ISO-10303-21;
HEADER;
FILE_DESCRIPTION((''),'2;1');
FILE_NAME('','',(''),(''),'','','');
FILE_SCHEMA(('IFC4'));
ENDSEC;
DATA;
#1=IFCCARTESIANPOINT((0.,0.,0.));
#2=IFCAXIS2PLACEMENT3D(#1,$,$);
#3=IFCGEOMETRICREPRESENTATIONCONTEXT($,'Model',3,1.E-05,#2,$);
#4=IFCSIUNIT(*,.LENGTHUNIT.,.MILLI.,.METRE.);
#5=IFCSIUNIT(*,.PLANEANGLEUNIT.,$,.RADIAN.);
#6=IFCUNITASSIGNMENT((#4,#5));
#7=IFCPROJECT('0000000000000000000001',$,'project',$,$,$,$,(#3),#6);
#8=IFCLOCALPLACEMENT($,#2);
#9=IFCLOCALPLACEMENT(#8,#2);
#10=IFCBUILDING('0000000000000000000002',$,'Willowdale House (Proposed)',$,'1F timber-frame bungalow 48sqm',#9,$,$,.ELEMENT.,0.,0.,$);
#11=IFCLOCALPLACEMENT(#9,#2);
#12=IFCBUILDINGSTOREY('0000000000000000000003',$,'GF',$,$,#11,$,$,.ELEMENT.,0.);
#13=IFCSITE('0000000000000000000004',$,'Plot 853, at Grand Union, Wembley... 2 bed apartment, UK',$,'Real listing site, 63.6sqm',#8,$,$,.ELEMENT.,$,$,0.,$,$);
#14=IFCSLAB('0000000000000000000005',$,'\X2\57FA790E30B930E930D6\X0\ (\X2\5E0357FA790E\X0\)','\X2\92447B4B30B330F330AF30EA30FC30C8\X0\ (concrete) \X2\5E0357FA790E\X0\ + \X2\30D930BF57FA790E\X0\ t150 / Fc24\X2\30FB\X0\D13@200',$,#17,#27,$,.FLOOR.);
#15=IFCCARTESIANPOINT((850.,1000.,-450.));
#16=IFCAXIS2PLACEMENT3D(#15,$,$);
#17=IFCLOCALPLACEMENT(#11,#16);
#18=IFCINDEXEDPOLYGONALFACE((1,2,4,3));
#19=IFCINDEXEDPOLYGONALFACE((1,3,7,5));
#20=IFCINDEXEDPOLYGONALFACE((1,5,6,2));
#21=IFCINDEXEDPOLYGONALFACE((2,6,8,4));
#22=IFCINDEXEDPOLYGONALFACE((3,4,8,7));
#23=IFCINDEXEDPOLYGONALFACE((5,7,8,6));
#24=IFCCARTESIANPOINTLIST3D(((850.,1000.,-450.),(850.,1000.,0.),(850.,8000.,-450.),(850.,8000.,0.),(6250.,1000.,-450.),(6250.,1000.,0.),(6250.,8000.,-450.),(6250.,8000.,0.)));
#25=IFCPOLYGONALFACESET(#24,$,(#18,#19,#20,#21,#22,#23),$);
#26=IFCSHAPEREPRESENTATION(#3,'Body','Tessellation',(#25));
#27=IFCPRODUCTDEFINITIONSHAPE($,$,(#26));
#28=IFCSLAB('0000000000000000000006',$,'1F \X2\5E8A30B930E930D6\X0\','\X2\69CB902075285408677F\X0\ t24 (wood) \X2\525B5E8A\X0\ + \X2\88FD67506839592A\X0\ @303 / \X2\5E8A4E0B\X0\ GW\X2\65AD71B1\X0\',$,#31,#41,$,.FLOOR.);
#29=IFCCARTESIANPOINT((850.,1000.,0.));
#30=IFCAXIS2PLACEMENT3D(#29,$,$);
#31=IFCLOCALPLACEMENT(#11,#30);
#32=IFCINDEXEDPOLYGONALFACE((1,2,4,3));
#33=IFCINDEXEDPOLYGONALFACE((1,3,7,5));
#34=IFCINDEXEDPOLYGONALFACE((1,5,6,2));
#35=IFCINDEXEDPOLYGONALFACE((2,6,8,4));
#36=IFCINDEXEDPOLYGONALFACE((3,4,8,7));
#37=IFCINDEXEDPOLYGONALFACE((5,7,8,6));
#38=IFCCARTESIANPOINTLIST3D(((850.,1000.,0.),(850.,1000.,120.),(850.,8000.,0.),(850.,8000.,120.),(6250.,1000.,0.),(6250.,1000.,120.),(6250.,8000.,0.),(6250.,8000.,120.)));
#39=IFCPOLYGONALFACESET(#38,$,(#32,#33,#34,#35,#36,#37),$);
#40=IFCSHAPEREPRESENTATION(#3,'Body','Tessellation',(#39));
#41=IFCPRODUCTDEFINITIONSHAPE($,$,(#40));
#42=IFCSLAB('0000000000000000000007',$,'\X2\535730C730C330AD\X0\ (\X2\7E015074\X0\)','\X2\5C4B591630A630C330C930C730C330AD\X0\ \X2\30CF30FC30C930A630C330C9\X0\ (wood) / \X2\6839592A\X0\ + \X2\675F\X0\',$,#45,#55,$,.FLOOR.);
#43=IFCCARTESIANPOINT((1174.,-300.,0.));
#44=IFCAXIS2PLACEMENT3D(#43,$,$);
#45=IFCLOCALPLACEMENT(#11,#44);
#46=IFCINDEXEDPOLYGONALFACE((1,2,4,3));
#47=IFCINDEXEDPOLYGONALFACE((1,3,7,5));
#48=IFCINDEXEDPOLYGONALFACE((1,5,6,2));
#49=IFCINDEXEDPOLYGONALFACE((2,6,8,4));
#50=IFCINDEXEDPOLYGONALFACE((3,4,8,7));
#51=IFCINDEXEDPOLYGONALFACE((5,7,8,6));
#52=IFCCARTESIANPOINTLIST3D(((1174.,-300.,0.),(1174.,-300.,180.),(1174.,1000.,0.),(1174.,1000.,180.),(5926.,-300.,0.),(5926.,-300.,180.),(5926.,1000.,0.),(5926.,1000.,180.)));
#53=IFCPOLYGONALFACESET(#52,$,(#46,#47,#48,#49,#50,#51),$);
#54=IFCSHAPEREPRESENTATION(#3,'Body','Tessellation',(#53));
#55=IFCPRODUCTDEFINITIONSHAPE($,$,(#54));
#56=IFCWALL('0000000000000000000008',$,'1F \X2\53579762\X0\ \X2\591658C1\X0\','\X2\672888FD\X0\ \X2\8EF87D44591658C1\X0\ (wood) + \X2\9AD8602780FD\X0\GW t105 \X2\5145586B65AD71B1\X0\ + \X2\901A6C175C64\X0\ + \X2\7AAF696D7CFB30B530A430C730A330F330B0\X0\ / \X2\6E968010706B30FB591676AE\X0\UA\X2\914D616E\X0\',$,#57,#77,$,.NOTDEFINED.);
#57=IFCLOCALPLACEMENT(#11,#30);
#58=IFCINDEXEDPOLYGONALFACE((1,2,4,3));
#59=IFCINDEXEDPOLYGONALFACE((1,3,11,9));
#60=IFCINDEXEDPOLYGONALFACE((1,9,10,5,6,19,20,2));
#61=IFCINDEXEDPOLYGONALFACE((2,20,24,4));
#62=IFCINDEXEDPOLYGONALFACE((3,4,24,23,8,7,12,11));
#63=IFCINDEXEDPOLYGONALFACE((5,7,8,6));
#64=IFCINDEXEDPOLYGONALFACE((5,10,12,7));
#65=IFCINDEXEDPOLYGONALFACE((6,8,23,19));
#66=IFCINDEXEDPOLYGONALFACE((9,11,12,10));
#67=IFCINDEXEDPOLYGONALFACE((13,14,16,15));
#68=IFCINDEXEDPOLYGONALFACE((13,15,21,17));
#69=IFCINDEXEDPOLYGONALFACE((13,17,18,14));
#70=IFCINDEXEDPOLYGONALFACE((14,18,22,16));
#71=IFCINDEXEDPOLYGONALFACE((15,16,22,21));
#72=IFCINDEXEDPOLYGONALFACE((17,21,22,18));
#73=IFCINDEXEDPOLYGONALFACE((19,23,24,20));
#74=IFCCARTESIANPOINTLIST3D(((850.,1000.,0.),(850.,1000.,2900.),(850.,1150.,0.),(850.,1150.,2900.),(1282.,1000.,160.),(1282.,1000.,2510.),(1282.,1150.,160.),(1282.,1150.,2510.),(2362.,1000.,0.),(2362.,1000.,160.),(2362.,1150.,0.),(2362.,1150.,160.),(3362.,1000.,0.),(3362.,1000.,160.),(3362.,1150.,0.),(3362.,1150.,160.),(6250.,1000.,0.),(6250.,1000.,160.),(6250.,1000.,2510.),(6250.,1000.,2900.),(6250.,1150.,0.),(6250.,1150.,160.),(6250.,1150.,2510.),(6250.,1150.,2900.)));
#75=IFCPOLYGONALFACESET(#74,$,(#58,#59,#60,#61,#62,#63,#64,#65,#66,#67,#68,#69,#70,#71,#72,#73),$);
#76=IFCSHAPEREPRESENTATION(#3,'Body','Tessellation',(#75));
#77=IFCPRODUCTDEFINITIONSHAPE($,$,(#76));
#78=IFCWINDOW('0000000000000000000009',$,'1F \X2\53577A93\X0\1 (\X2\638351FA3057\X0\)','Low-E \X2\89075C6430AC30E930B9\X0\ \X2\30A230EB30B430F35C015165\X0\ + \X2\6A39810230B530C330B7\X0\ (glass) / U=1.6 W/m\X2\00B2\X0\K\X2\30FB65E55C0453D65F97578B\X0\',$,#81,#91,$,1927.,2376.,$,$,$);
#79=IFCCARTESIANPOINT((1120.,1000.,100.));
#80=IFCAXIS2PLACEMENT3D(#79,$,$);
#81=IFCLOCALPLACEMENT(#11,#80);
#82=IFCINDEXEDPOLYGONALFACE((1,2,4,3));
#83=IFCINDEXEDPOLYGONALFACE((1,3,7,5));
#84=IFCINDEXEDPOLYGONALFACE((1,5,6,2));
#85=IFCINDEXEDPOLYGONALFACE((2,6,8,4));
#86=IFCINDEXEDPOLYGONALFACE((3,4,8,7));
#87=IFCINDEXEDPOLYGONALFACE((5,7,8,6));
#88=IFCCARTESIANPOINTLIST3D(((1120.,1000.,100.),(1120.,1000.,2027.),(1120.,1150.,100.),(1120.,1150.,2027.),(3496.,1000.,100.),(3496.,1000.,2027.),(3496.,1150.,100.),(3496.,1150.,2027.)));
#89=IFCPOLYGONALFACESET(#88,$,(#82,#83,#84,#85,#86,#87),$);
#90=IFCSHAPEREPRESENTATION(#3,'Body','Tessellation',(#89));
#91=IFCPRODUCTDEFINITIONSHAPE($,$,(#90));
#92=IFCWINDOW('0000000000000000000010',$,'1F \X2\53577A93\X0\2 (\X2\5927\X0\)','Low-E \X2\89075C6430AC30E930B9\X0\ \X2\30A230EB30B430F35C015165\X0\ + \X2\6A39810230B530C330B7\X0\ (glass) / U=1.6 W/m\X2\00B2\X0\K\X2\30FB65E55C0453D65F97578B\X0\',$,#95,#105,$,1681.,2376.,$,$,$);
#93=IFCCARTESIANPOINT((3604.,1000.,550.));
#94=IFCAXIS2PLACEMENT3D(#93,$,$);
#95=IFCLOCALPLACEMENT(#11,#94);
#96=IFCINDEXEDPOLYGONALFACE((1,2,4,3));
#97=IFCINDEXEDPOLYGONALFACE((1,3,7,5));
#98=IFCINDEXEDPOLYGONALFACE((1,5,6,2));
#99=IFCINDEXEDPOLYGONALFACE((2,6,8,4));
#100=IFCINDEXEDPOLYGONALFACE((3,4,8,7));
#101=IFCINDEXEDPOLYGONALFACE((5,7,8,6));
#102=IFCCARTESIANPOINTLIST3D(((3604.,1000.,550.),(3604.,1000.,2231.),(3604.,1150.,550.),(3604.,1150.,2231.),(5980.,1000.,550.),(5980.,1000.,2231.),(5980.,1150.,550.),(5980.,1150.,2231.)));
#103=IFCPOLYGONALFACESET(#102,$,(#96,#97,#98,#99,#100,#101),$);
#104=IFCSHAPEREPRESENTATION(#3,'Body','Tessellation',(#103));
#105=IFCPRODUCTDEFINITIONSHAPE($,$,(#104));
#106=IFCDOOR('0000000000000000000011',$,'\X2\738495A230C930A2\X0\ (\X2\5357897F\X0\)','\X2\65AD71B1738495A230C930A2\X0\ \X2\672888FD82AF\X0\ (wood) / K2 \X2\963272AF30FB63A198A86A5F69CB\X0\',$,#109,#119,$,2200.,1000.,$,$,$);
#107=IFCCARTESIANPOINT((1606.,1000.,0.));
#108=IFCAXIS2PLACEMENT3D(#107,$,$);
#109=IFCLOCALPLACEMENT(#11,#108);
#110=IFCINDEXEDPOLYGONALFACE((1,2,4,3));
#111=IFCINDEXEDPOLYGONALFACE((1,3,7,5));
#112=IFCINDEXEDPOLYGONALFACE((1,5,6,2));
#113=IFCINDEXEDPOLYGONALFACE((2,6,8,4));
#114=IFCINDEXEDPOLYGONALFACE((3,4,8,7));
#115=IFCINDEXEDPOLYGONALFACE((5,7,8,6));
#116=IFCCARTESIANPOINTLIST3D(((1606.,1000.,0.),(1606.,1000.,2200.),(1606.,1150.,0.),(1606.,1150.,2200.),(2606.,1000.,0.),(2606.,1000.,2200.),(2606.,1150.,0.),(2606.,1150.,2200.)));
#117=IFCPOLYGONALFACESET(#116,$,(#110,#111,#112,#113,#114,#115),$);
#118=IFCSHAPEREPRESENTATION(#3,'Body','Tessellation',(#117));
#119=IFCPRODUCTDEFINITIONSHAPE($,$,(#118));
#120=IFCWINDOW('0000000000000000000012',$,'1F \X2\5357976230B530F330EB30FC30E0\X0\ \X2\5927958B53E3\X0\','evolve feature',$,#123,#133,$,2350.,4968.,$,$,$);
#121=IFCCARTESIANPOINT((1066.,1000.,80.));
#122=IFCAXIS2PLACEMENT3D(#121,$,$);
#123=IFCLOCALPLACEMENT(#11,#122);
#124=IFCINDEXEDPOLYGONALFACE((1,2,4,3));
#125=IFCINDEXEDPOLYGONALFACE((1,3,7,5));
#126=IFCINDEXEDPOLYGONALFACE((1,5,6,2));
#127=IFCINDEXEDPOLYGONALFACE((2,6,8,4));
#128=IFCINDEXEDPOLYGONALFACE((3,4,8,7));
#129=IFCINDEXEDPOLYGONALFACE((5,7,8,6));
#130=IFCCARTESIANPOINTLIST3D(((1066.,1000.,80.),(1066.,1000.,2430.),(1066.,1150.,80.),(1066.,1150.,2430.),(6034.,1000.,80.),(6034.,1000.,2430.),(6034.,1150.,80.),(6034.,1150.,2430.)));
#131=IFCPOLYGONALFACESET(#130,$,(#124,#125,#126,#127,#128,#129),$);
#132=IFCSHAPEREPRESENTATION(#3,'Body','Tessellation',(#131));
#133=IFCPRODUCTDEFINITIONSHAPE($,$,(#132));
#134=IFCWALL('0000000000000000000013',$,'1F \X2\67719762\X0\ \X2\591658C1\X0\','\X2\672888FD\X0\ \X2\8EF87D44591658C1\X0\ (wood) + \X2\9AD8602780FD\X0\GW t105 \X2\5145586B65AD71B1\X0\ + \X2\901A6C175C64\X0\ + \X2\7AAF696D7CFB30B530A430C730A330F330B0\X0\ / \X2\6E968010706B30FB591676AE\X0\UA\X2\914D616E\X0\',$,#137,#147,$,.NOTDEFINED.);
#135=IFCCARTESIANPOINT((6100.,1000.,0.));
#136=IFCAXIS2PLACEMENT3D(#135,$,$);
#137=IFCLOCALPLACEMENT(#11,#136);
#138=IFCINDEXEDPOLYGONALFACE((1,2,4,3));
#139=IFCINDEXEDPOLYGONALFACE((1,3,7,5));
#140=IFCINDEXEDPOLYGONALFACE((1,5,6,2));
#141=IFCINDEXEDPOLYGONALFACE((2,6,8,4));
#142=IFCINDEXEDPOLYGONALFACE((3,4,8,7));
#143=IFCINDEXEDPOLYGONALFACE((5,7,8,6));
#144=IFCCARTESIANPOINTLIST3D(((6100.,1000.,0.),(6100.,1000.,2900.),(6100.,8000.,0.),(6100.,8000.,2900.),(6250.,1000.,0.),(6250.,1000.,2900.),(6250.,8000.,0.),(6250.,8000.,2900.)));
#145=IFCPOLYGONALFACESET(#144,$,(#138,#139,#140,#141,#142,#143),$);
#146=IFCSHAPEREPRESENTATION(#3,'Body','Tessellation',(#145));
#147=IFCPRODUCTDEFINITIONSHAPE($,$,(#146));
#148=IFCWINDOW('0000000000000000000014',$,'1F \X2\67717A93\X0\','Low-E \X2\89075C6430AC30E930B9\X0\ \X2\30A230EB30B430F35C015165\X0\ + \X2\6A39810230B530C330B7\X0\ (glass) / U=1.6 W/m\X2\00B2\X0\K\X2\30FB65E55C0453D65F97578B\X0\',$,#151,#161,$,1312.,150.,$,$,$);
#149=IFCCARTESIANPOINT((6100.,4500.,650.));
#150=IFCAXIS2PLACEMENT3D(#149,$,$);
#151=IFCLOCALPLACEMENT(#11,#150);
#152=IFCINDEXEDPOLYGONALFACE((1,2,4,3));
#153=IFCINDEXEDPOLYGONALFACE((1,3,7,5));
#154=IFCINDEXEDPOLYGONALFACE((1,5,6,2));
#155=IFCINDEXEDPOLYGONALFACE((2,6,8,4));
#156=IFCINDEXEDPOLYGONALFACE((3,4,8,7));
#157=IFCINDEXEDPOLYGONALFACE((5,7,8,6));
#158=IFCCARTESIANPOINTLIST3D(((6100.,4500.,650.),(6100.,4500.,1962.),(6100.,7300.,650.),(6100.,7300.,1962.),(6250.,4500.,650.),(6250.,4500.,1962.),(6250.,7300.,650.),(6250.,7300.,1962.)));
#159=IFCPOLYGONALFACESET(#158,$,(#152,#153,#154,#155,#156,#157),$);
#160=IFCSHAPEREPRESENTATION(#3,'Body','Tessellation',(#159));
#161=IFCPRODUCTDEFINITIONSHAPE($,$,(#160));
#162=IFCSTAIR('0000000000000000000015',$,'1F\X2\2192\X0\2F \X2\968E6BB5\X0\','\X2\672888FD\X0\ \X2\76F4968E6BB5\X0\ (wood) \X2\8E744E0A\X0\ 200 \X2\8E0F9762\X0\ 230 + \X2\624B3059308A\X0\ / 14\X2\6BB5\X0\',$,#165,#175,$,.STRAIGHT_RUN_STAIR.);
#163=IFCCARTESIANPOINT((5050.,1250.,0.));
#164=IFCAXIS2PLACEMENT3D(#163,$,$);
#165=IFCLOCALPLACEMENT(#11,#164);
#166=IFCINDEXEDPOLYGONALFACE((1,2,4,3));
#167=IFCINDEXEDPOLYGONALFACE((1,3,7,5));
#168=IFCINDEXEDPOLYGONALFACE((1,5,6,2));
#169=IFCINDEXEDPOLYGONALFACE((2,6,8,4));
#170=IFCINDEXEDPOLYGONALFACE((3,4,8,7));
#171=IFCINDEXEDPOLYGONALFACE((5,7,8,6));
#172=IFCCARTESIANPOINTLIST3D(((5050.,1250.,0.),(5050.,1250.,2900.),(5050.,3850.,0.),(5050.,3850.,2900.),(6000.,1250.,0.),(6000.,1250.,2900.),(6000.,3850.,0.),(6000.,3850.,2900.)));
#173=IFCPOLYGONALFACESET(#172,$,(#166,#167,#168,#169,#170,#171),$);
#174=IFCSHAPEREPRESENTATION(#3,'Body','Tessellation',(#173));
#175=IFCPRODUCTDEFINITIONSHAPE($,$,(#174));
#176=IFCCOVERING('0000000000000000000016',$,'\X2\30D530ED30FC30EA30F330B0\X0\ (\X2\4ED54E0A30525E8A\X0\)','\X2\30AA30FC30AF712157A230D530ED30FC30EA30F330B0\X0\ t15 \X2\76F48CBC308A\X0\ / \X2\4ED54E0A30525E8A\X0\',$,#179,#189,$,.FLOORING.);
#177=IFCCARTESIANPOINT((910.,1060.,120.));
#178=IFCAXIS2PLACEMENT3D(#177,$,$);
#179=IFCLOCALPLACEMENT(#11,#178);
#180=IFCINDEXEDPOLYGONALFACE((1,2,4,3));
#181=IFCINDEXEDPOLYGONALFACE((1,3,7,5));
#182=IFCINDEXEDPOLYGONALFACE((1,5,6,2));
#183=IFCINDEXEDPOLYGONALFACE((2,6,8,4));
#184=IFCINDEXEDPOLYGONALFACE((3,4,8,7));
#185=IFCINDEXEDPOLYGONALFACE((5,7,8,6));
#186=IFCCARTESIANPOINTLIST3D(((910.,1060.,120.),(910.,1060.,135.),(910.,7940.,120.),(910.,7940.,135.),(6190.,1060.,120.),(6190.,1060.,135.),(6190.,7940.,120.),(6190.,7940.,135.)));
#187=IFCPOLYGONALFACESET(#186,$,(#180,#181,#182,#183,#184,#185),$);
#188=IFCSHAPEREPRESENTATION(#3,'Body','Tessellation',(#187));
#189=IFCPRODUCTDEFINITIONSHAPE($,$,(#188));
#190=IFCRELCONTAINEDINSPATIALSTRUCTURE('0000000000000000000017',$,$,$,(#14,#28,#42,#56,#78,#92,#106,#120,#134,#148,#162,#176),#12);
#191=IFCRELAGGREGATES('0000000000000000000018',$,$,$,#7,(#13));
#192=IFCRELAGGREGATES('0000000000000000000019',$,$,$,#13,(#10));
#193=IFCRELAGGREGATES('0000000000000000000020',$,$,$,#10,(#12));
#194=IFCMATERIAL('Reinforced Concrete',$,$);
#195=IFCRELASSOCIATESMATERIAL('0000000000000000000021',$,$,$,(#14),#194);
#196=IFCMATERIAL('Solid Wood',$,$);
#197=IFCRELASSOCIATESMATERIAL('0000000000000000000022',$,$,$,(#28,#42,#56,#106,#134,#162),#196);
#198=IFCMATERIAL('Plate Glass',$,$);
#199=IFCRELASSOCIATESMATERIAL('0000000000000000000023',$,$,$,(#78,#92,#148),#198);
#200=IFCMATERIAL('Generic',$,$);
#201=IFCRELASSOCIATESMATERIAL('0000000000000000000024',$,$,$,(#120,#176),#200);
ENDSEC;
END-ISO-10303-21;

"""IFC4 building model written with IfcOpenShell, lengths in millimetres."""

from ifc_helpers import new_model, si_unit, frame, frame_2d, origin, place, context, project, spatial, rectangle, extrude, material, element, fill, save


model = new_model("IFC4")

# Units and contexts
model_context = context("Model", 3, precision=1e-05, world=origin())
ifc_project = project(units=[si_unit("LENGTHUNIT", "METRE", prefix="MILLI"), si_unit("PLANEANGLEUNIT", "RADIAN")], contexts=[model_context])

# Site, building, storey
site_placement = place(None, origin())
site = spatial("IfcSite", under=ifc_project, at=site_placement, Name="Plot 853, at Grand Union, Wembley... 2 bed apartment, UK", ObjectType="Real listing site, 63.6sqm", CompositionType="ELEMENT", RefElevation=0.0)
building_placement = place(site_placement, origin())
building = spatial("IfcBuilding", under=site, at=building_placement, Name="Willowdale House (Proposed)", ObjectType="1F timber-frame bungalow 48sqm", CompositionType="ELEMENT", ElevationOfRefHeight=0.0, ElevationOfTerrain=0.0)
storey_placement = place(building_placement, origin())
storey = spatial("IfcBuildingStorey", under=building, at=storey_placement, Name="GF", CompositionType="ELEMENT", Elevation=0.0)

# Slabs
ifc_material_1 = material(Name="Reinforced Concrete")
slab_1_placement = place(storey_placement, frame((850.0, 1000.0, -450.0)))
element("IfcSlab", 1, at=slab_1_placement, inside=storey, material=ifc_material_1, Name="基礎スラブ (布基礎)", Description="鉄筋コンクリート (concrete) 布基礎 + ベタ基礎 t150 / Fc24・D13@200", PredefinedType="FLOOR", context=model_context, shape_type="SweptSolid", body=[
    extrude(rectangle(XDim=5400.0, YDim=7000.0, at=frame_2d((2700.0, 3500.0))), frame((850.0, 1000.0, -450.0)), (0.0, 0.0, 1.0), 450.0),
])
ifc_material_2 = material(Name="Solid Wood")
slab_2_placement = place(storey_placement, frame((850.0, 1000.0, 0.0)))
element("IfcSlab", 2, at=slab_2_placement, inside=storey, material=ifc_material_2, Name="1F 床スラブ", Description="構造用合板 t24 (wood) 剛床 + 製材根太 @303 / 床下 GW断熱", PredefinedType="FLOOR", context=model_context, shape_type="SweptSolid", body=[
    extrude(rectangle(XDim=5400.0, YDim=7000.0, at=frame_2d((2700.0, 3500.0))), frame((850.0, 1000.0, 0.0)), (0.0, 0.0, 1.0), 120.0),
])
slab_3_placement = place(storey_placement, frame((1174.0, -300.0, 0.0)))
element("IfcSlab", 3, at=slab_3_placement, inside=storey, material=ifc_material_2, Name="南デッキ (縁側)", Description="屋外ウッドデッキ ハードウッド (wood) / 根太 + 束", PredefinedType="FLOOR", context=model_context, shape_type="SweptSolid", body=[
    extrude(rectangle(XDim=4752.0, YDim=1300.0, at=frame_2d((2376.0, 650.0))), frame((1174.0, -300.0, 0.0)), (0.0, 0.0, 1.0), 180.0),
])

# Wall, openings, windows, door
wall_1_placement = place(storey_placement, frame((850.0, 1000.0, 0.0)))
wall_1 = element("IfcWall", 4, at=wall_1_placement, inside=storey, material=ifc_material_2, Name="1F 南面 外壁", Description="木製 軸組外壁 (wood) + 高性能GW t105 充填断熱 + 通気層 + 窯業系サイディング / 準耐火・外皮UA配慮", PredefinedType="NOTDEFINED", context=model_context, shape_type="SweptSolid", body=[
    extrude(rectangle(XDim=5400.0, YDim=150.0, at=frame_2d((2700.0, 75.0))), frame((850.0, 1000.0, 0.0)), (0.0, 0.0, 1.0), 2900.0),
])
opening_1_placement = place(storey_placement, frame((1120.0, 1000.0, 100.0)))
opening_1 = element("IfcOpeningElement", 5, at=opening_1_placement, cuts=wall_1, PredefinedType="NOTDEFINED", context=model_context, shape_type="SweptSolid", body=[
    extrude(rectangle(XDim=2376.0, YDim=150.0, at=frame_2d((1188.0, 75.0))), frame((1120.0, 1000.0, 100.0)), (0.0, 0.0, 1.0), 1927.0),
])
opening_2_placement = place(storey_placement, frame((3604.0, 1000.0, 550.0)))
opening_2 = element("IfcOpeningElement", 6, at=opening_2_placement, cuts=wall_1, PredefinedType="NOTDEFINED", context=model_context, shape_type="SweptSolid", body=[
    extrude(rectangle(XDim=2376.0, YDim=150.0, at=frame_2d((1188.0, 75.0))), frame((3604.0, 1000.0, 550.0)), (0.0, 0.0, 1.0), 1681.0),
])
opening_3_placement = place(storey_placement, frame((1606.0, 1000.0, 0.0)))
opening_3 = element("IfcOpeningElement", 7, at=opening_3_placement, cuts=wall_1, PredefinedType="NOTDEFINED", context=model_context, shape_type="SweptSolid", body=[
    extrude(rectangle(XDim=1000.0, YDim=150.0, at=frame_2d((500.0, 75.0))), frame((1606.0, 1000.0, 0.0)), (0.0, 0.0, 1.0), 2200.0),
])
opening_4_placement = place(storey_placement, frame((1066.0, 1000.0, 80.0)))
opening_4 = element("IfcOpeningElement", 8, at=opening_4_placement, cuts=wall_1, PredefinedType="NOTDEFINED", context=model_context, shape_type="SweptSolid", body=[
    extrude(rectangle(XDim=4968.0, YDim=150.0, at=frame_2d((2484.0, 75.0))), frame((1066.0, 1000.0, 80.0)), (0.0, 0.0, 1.0), 2350.0),
])
ifc_material_3 = material(Name="Plate Glass")
window_1_placement = place(storey_placement, frame((1120.0, 1000.0, 100.0)))
window_1 = element("IfcWindow", 9, at=window_1_placement, inside=storey, material=ifc_material_3, Name="1F 南窓1 (掃出し)", Description="Low-E 複層ガラス アルゴン封入 + 樹脂サッシ (glass) / U=1.6 W/m²K・日射取得型", OverallHeight=1927.0, OverallWidth=2376.0, context=model_context, shape_type="SweptSolid", body=[
    extrude(rectangle(XDim=2376.0, YDim=150.0, at=frame_2d((1188.0, 75.0))), frame((1120.0, 1000.0, 100.0)), (0.0, 0.0, 1.0), 1927.0),
])
fill(opening_1, window_1)
window_2_placement = place(storey_placement, frame((3604.0, 1000.0, 550.0)))
window_2 = element("IfcWindow", 10, at=window_2_placement, inside=storey, material=ifc_material_3, Name="1F 南窓2 (大)", Description="Low-E 複層ガラス アルゴン封入 + 樹脂サッシ (glass) / U=1.6 W/m²K・日射取得型", OverallHeight=1681.0, OverallWidth=2376.0, context=model_context, shape_type="SweptSolid", body=[
    extrude(rectangle(XDim=2376.0, YDim=150.0, at=frame_2d((1188.0, 75.0))), frame((3604.0, 1000.0, 550.0)), (0.0, 0.0, 1.0), 1681.0),
])
fill(opening_2, window_2)
door_placement = place(storey_placement, frame((1606.0, 1000.0, 0.0)))
door = element("IfcDoor", 11, at=door_placement, inside=storey, material=ifc_material_2, Name="玄関ドア (南西)", Description="断熱玄関ドア 木製芯 (wood) / K2 防犯・採風機構", OverallHeight=2200.0, OverallWidth=1000.0, context=model_context, shape_type="SweptSolid", body=[
    extrude(rectangle(XDim=1000.0, YDim=150.0, at=frame_2d((500.0, 75.0))), frame((1606.0, 1000.0, 0.0)), (0.0, 0.0, 1.0), 2200.0),
])
fill(opening_3, door)
ifc_material_4 = material(Name="Generic")
window_3_placement = place(storey_placement, frame((1066.0, 1000.0, 80.0)))
window_3 = element("IfcWindow", 12, at=window_3_placement, inside=storey, material=ifc_material_4, Name="1F 南面サンルーム 大開口", Description="evolve feature", OverallHeight=2350.0, OverallWidth=4968.0, context=model_context, shape_type="SweptSolid", body=[
    extrude(rectangle(XDim=4968.0, YDim=150.0, at=frame_2d((2484.0, 75.0))), frame((1066.0, 1000.0, 80.0)), (0.0, 0.0, 1.0), 2350.0),
])
fill(opening_4, window_3)

# Wall, opening, window
wall_2_placement = place(storey_placement, frame((6100.0, 1000.0, 0.0)))
wall_2 = element("IfcWall", 13, at=wall_2_placement, inside=storey, material=ifc_material_2, Name="1F 東面 外壁", Description="木製 軸組外壁 (wood) + 高性能GW t105 充填断熱 + 通気層 + 窯業系サイディング / 準耐火・外皮UA配慮", PredefinedType="NOTDEFINED", context=model_context, shape_type="SweptSolid", body=[
    extrude(rectangle(XDim=150.0, YDim=7000.0, at=frame_2d((75.0, 3500.0))), frame((6100.0, 1000.0, 0.0)), (0.0, 0.0, 1.0), 2900.0),
])
opening_5_placement = place(storey_placement, frame((6100.0, 4500.0, 650.0)))
opening_5 = element("IfcOpeningElement", 14, at=opening_5_placement, cuts=wall_2, PredefinedType="NOTDEFINED", context=model_context, shape_type="SweptSolid", body=[
    extrude(rectangle(XDim=150.0, YDim=2800.0, at=frame_2d((75.0, 1400.0))), frame((6100.0, 4500.0, 650.0)), (0.0, 0.0, 1.0), 1312.0),
])
window_4_placement = place(storey_placement, frame((6100.0, 4500.0, 650.0)))
window_4 = element("IfcWindow", 15, at=window_4_placement, inside=storey, material=ifc_material_3, Name="1F 東窓", Description="Low-E 複層ガラス アルゴン封入 + 樹脂サッシ (glass) / U=1.6 W/m²K・日射取得型", OverallHeight=1312.0, OverallWidth=150.0, context=model_context, shape_type="SweptSolid", body=[
    extrude(rectangle(XDim=150.0, YDim=2800.0, at=frame_2d((75.0, 1400.0))), frame((6100.0, 4500.0, 650.0)), (0.0, 0.0, 1.0), 1312.0),
])
fill(opening_5, window_4)

# Stair
stair_placement = place(storey_placement, frame((5050.0, 1250.0, 0.0)))
element("IfcStair", 16, at=stair_placement, inside=storey, material=ifc_material_2, Name="1F→2F 階段", Description="木製 直階段 (wood) 蹴上 200 踏面 230 + 手すり / 14段", PredefinedType="STRAIGHT_RUN_STAIR", context=model_context, shape_type="SweptSolid", body=[
    extrude(rectangle(XDim=950.0, YDim=2600.0, at=frame_2d((475.0, 1300.0))), frame((5050.0, 1250.0, 0.0)), (0.0, 0.0, 1.0), 2900.0),
])

# Covering
covering_placement = place(storey_placement, frame((910.0, 1060.0, 120.0)))
element("IfcCovering", 17, at=covering_placement, inside=storey, material=ifc_material_4, Name="フローリング (仕上げ床)", Description="オーク無垢フローリング t15 直貼り / 仕上げ床", PredefinedType="FLOORING", context=model_context, shape_type="SweptSolid", body=[
    extrude(rectangle(XDim=5280.0, YDim=6880.0, at=frame_2d((2640.0, 3440.0))), frame((910.0, 1060.0, 120.0)), (0.0, 0.0, 1.0), 15.0),
])

save(model, "model.ifc")
